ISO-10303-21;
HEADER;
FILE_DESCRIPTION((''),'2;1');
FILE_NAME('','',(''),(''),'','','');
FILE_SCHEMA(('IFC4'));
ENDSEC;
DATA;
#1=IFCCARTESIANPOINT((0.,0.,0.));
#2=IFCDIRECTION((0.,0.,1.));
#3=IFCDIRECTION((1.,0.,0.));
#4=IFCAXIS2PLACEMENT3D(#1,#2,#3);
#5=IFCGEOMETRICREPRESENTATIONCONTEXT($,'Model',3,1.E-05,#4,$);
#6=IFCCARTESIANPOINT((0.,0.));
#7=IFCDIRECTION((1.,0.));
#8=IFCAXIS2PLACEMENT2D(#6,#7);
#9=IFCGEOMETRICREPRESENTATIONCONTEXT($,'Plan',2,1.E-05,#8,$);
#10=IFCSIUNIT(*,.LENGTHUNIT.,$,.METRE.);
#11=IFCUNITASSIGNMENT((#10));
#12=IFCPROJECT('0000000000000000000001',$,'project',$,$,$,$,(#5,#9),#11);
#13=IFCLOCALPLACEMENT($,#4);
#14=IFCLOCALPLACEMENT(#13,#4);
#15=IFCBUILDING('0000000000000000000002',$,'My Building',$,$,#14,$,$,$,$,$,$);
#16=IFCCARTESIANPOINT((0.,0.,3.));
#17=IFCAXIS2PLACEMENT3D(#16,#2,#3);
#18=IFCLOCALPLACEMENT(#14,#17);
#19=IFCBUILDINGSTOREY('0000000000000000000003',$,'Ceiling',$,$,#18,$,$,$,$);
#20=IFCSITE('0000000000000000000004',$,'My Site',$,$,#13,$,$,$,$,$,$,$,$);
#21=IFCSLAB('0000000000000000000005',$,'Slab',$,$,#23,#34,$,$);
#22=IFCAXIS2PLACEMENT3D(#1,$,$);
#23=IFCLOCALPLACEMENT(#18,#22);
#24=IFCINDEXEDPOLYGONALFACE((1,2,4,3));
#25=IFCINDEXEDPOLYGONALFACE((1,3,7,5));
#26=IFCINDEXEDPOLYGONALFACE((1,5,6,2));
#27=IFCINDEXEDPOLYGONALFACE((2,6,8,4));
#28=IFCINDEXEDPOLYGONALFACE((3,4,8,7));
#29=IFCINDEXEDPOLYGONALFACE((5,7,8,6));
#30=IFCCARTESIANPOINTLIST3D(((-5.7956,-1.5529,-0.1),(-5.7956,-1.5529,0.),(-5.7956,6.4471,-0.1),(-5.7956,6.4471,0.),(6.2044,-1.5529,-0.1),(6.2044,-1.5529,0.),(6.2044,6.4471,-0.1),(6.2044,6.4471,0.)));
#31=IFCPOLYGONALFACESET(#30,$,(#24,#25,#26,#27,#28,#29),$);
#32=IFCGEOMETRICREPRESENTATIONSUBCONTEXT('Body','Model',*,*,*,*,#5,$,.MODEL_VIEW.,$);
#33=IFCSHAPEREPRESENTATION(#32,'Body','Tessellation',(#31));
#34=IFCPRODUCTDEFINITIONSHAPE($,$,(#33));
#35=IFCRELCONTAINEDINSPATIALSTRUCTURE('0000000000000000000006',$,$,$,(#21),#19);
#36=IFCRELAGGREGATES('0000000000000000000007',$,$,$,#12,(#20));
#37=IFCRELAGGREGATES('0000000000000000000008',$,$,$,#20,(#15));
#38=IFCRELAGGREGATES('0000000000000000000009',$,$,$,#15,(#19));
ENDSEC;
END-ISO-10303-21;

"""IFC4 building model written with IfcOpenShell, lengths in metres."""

from ifc_helpers import new_model, si_unit, frame, origin_with_axes, origin_2d_with_axis, place, context, subcontext, project, spatial, indexed_curve, outline, extrude, element, save


model = new_model("IFC4")

# Units and contexts
model_context = context("Model", 3, precision=1e-05, world=origin_with_axes())
plan_context = context("Plan", 2, precision=1e-05, world=origin_2d_with_axis())
body_context = subcontext(model_context, "Body", "Model", "MODEL_VIEW")
ifc_project = project(units=[si_unit("LENGTHUNIT", "METRE")], contexts=[model_context, plan_context])

# Site, building, storey
site_placement = place(None, origin_with_axes())
site = spatial("IfcSite", under=ifc_project, at=site_placement, Name="My Site")
building_placement = place(site_placement, origin_with_axes())
building = spatial("IfcBuilding", under=site, at=building_placement, Name="My Building")
storey_placement = place(building_placement, frame((0.0, 0.0, 3.0), z_axis=(0.0, 0.0, 1.0), x_axis=(1.0, 0.0, 0.0)))
storey = spatial("IfcBuildingStorey", under=building, at=storey_placement, Name="Ceiling")

# Slab
slab_placement = place(storey_placement, frame((-5.7956, 6.4471, 0.0), z_axis=(0.0, 0.0, 1.0), x_axis=(1.0, 0.0, 0.0)))
element("IfcSlab", 1, at=slab_placement, inside=storey, Name="Slab", context=body_context, shape_type="SweptSolid", body=[
    extrude(outline(indexed_curve([(0.0, 0.0), (12.0, 0.0), (12.0, -8.0), (0.0, -8.0), (0.0, 0.0)])), frame((0.0, 0.0, -0.1), z_axis=(0.0, 0.0, 1.0), x_axis=(1.0, 0.0, 0.0)), (0.0, 0.0, 1.0), 0.1),
])

save(model, "model.ifc")
